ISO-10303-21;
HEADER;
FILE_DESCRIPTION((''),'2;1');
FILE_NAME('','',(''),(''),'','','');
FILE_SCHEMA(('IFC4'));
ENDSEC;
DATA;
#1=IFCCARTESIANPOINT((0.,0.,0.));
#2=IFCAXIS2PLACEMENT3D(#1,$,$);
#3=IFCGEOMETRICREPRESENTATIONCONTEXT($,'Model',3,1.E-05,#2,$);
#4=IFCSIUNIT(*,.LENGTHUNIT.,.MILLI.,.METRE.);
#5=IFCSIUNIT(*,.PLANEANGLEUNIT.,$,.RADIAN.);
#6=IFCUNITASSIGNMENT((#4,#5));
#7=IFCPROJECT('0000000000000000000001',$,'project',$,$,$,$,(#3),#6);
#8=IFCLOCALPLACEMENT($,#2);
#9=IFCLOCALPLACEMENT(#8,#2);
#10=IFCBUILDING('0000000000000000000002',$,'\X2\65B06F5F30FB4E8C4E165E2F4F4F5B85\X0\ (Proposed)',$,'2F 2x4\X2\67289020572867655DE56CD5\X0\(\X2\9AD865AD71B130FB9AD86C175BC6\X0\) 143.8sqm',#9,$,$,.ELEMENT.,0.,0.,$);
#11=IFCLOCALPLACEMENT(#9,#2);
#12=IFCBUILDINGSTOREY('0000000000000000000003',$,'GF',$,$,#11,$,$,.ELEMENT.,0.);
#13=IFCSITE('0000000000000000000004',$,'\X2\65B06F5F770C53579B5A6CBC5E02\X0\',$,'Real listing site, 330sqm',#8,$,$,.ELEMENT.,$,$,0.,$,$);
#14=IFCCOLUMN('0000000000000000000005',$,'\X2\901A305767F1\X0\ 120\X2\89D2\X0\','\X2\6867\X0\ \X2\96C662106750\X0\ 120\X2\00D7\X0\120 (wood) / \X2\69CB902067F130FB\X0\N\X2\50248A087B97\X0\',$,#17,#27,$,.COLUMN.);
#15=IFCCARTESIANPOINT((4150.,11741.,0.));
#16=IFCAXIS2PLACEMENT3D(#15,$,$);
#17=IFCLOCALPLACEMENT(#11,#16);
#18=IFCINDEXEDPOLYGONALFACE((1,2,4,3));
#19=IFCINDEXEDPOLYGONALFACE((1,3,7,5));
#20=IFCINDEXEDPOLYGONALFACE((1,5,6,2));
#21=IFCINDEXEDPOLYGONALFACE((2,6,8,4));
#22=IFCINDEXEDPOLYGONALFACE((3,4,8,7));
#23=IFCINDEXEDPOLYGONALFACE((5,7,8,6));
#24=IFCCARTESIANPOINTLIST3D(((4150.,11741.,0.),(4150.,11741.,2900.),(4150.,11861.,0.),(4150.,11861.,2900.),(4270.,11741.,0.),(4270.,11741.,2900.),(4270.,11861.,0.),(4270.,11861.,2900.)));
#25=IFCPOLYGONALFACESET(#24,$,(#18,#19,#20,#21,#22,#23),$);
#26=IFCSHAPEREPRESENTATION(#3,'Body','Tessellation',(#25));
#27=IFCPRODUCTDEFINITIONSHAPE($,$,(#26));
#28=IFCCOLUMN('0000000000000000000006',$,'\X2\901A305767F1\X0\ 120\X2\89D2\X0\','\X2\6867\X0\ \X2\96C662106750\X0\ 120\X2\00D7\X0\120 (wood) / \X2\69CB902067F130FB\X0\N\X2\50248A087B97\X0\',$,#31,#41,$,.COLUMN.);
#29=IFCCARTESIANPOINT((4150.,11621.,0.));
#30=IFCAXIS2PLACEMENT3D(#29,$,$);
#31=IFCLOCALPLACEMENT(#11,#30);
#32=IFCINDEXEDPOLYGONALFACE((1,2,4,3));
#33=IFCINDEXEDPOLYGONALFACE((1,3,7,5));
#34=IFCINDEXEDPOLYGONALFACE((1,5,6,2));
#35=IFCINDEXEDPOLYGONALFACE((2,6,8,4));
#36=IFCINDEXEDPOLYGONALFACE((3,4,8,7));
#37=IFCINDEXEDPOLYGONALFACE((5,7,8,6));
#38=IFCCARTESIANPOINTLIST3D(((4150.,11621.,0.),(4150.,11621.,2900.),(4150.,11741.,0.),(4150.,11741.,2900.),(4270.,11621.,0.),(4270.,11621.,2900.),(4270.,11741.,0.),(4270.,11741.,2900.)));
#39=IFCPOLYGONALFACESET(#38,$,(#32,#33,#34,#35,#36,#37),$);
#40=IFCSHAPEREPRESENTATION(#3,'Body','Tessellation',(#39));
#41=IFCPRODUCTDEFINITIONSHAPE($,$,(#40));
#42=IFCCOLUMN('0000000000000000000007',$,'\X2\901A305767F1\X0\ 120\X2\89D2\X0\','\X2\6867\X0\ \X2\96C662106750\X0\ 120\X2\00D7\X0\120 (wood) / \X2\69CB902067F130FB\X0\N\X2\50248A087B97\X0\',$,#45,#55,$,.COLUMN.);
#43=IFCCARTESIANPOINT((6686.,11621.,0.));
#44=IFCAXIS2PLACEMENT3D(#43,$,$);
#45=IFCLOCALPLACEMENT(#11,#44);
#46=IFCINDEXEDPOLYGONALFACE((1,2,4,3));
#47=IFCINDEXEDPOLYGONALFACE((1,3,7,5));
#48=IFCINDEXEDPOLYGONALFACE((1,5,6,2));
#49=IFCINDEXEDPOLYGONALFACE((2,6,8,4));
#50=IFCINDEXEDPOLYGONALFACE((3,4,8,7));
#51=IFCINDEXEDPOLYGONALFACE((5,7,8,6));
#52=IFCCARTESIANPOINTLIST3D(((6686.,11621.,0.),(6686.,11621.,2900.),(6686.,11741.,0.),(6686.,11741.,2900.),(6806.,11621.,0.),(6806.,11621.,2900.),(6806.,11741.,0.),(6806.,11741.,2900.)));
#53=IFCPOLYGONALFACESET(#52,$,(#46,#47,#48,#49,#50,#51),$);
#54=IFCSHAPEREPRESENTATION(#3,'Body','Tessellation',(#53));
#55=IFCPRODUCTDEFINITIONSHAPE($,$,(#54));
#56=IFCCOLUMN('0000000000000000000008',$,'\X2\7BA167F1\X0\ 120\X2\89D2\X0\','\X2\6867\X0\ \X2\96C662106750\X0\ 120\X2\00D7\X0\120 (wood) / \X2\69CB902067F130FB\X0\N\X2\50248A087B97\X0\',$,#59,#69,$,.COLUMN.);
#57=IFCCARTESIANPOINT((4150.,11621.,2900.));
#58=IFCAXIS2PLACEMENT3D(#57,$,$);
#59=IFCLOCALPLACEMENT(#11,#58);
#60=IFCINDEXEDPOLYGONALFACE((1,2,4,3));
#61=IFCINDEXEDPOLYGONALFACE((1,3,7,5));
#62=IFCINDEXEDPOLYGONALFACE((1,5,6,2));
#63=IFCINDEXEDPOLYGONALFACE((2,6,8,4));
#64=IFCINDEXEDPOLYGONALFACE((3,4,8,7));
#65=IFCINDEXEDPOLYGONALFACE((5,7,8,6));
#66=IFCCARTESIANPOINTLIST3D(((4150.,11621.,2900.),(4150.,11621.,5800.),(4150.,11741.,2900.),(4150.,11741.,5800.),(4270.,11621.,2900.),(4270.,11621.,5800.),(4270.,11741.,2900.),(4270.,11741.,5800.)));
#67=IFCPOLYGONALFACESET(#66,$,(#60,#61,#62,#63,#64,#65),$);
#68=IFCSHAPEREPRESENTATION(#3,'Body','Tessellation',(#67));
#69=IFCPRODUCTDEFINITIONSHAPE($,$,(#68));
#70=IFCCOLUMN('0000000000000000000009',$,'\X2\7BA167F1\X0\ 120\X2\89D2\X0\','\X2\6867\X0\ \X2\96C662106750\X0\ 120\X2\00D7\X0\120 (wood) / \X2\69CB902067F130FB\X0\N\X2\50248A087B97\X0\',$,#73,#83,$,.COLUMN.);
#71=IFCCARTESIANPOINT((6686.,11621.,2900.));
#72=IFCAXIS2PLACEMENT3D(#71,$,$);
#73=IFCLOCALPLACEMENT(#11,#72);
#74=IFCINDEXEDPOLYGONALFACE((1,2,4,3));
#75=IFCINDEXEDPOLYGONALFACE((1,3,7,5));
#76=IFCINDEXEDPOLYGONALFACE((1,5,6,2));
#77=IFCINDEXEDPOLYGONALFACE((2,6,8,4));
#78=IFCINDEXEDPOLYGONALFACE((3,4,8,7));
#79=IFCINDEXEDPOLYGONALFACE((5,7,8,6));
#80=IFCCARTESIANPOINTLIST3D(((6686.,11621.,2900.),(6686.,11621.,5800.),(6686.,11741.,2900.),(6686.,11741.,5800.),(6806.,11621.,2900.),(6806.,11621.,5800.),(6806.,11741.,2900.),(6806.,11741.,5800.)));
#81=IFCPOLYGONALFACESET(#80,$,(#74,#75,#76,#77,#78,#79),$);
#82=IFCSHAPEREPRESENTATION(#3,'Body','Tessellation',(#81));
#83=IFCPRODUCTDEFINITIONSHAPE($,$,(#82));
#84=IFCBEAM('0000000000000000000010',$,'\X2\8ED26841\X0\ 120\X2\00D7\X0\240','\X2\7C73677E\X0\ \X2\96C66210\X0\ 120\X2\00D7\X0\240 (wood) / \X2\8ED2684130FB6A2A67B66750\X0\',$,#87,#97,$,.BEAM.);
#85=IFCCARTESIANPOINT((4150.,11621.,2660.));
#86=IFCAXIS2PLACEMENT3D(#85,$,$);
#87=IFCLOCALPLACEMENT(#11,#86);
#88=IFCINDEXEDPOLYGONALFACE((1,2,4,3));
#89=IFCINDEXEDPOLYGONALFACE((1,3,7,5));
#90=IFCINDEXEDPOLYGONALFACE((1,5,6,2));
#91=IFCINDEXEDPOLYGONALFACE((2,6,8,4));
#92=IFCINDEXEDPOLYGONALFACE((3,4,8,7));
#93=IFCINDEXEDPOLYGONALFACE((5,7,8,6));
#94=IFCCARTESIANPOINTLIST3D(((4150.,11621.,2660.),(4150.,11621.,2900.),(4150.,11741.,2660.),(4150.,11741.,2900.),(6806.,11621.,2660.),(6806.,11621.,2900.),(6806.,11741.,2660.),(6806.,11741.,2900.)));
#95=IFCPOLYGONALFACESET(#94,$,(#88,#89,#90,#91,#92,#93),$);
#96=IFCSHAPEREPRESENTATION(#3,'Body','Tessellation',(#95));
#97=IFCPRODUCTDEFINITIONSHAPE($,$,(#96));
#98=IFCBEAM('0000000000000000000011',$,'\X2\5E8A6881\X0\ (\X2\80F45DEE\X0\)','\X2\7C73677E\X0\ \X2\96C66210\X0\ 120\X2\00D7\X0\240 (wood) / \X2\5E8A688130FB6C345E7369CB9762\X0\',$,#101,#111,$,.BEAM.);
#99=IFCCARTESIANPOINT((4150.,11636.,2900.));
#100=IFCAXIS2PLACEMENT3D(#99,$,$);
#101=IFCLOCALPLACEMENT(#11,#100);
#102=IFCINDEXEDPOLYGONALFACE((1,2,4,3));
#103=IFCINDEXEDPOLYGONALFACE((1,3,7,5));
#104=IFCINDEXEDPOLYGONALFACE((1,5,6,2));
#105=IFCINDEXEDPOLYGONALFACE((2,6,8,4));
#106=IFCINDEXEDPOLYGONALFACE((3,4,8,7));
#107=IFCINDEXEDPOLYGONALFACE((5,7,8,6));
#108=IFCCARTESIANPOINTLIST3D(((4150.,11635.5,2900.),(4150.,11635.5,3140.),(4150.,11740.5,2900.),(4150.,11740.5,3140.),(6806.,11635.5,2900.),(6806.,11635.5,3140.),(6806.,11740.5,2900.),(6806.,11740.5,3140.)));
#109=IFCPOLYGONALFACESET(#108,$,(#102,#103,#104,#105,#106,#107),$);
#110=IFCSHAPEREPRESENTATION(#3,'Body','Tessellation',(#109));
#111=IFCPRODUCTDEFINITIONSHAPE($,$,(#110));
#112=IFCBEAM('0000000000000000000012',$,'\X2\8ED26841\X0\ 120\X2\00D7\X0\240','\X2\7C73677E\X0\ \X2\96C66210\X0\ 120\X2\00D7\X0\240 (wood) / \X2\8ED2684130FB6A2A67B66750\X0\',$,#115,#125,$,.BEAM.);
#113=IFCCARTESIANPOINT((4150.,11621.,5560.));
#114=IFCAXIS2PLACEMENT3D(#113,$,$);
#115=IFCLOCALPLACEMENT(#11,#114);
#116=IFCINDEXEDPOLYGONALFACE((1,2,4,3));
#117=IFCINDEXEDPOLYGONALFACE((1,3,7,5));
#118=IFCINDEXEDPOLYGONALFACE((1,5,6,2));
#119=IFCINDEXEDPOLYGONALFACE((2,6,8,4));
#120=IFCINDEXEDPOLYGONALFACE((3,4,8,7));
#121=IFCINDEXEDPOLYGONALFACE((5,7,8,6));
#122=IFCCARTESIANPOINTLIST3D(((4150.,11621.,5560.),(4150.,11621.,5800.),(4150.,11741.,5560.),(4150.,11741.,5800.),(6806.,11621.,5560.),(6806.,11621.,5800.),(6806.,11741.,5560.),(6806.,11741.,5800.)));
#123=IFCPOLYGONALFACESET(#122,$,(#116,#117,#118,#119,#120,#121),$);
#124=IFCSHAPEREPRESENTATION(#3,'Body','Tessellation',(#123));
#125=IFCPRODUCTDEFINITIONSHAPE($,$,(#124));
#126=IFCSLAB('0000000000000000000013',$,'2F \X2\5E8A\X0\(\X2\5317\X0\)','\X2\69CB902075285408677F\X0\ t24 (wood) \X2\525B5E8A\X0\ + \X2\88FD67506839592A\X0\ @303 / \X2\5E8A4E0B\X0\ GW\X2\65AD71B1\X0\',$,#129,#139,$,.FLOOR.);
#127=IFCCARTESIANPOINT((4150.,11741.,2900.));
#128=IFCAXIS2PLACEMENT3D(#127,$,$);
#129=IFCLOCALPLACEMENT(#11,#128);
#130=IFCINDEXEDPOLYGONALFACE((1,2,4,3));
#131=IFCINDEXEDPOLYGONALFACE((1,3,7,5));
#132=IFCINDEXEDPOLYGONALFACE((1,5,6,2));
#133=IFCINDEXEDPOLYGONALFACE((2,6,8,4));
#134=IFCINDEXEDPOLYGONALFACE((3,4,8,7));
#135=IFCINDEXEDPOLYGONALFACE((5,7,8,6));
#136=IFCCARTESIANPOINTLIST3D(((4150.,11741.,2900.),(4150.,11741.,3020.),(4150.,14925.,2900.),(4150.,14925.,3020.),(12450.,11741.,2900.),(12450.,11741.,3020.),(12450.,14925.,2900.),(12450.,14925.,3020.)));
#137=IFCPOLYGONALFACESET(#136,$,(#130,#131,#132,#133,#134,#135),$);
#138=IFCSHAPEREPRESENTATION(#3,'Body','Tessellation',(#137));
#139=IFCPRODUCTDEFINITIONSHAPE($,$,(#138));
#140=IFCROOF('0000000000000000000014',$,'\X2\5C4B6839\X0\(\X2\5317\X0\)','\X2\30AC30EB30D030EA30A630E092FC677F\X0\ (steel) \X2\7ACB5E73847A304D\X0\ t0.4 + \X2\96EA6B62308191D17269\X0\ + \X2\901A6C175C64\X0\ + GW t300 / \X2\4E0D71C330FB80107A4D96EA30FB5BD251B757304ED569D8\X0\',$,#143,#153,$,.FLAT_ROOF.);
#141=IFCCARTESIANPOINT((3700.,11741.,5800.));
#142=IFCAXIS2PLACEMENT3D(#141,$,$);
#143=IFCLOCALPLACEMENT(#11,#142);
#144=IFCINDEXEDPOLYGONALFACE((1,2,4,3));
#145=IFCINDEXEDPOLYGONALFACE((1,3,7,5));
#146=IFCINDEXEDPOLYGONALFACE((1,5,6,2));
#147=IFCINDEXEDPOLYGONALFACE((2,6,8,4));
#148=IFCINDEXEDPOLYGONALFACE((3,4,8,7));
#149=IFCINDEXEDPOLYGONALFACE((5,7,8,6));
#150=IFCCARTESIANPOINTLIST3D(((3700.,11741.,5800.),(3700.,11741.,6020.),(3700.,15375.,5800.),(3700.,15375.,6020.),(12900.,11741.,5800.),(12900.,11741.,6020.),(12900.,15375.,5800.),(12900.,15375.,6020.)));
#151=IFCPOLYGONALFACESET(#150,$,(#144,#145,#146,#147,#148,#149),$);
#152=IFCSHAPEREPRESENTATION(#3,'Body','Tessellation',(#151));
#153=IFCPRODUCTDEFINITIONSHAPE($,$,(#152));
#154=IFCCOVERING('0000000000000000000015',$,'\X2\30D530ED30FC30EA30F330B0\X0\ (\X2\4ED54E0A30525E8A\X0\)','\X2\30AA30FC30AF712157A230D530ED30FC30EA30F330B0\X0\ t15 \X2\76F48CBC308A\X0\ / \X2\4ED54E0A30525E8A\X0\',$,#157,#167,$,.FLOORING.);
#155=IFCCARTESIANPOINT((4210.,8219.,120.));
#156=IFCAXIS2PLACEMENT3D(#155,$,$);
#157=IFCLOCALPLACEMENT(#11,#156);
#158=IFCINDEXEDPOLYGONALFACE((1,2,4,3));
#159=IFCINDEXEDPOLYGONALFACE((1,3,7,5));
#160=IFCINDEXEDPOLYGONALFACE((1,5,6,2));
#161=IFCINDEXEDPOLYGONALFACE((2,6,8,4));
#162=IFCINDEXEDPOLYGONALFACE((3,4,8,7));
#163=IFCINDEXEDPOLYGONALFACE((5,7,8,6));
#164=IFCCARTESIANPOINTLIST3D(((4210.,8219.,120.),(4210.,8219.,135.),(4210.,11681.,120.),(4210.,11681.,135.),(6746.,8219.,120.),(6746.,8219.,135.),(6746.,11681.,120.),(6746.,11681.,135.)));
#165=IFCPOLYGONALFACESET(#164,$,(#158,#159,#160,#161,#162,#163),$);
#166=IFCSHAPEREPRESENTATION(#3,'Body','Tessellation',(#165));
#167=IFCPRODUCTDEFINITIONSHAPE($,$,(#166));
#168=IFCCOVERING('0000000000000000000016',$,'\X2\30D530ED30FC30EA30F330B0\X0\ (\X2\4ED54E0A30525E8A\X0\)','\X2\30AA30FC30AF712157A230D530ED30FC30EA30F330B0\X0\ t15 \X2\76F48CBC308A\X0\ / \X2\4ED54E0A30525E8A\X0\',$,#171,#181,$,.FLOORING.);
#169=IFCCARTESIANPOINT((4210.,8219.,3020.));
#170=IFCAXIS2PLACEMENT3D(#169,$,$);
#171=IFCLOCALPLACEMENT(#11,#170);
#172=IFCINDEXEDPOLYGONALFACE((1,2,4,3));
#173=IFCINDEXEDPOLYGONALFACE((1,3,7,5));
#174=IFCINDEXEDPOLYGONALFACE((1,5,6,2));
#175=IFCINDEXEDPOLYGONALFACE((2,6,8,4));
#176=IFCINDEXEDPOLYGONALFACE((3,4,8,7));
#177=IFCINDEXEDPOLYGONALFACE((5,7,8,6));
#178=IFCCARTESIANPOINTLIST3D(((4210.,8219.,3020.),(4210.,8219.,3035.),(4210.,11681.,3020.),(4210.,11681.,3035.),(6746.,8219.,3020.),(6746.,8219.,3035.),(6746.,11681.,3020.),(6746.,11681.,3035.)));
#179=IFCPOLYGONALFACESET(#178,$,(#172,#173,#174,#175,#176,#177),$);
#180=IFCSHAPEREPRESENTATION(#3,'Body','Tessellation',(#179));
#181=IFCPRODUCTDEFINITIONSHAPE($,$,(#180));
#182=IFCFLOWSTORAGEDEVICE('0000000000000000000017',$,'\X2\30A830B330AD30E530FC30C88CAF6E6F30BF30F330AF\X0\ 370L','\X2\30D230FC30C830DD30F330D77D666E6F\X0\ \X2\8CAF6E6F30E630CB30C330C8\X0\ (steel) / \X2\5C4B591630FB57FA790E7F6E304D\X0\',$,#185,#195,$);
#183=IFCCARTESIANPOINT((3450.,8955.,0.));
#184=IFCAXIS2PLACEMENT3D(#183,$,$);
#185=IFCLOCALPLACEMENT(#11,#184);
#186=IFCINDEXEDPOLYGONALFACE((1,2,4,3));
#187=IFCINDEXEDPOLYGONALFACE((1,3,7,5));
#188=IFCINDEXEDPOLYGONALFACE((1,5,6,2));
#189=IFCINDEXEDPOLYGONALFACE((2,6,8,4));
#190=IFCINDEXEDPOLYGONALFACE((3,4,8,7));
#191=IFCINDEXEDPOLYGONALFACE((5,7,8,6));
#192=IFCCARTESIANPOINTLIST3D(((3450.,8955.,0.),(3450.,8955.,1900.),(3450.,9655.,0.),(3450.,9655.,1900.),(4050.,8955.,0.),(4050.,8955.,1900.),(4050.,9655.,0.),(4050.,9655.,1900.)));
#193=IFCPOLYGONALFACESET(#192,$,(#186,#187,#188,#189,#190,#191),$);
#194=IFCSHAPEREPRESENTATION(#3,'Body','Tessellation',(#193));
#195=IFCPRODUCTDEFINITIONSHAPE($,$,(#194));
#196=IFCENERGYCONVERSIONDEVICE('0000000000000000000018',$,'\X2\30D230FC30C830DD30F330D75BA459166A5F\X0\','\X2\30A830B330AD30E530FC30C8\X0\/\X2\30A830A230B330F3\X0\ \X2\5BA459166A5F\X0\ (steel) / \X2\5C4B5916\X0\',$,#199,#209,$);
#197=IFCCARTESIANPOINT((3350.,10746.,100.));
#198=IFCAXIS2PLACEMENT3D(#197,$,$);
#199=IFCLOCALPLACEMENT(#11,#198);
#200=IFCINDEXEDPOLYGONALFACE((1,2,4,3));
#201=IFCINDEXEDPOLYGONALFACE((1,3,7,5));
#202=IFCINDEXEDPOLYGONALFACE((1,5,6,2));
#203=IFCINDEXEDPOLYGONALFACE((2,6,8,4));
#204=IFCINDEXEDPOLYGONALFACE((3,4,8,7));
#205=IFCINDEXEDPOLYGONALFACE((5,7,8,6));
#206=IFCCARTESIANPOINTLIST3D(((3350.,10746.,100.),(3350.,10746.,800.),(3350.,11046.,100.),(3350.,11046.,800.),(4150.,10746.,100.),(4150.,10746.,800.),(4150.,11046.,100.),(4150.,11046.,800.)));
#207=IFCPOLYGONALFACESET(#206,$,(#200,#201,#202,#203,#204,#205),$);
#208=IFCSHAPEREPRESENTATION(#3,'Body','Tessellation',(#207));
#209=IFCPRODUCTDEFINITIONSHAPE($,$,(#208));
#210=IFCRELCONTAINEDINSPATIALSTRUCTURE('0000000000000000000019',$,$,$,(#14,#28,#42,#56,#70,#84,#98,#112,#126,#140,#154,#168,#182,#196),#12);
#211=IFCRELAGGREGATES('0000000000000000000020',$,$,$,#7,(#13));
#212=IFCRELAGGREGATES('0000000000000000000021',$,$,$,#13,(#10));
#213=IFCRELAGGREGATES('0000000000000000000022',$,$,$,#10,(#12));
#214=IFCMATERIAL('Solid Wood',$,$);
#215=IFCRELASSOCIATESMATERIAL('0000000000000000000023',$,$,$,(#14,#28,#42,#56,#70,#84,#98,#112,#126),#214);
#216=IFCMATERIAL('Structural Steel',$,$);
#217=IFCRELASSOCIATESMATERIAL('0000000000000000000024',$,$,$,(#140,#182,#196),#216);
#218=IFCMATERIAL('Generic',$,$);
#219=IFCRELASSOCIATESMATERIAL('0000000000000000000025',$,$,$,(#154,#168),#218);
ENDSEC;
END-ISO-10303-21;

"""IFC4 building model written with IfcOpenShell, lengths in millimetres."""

from ifc_helpers import new_model, si_unit, frame, frame_2d, origin, place, context, project, spatial, rectangle, extrude, material, element, save


model = new_model("IFC4")

# Units and contexts
model_context = context("Model", 3, precision=1e-05, world=origin())
ifc_project = project(units=[si_unit("LENGTHUNIT", "METRE", prefix="MILLI"), si_unit("PLANEANGLEUNIT", "RADIAN")], contexts=[model_context])

# Site, building, storey
site_placement = place(None, origin())
site = spatial("IfcSite", under=ifc_project, at=site_placement, Name="新潟県南魚沼市", ObjectType="Real listing site, 330sqm", CompositionType="ELEMENT", RefElevation=0.0)
building_placement = place(site_placement, origin())
building = spatial("IfcBuilding", under=site, at=building_placement, Name="新潟・二世帯住宅 (Proposed)", ObjectType="2F 2x4木造在来工法(高断熱・高気密) 143.8sqm", CompositionType="ELEMENT", ElevationOfRefHeight=0.0, ElevationOfTerrain=0.0)
storey_placement = place(building_placement, origin())
storey = spatial("IfcBuildingStorey", under=building, at=storey_placement, Name="GF", CompositionType="ELEMENT", Elevation=0.0)

# Columns
ifc_material_1 = material(Name="Solid Wood")
column_1_placement = place(storey_placement, frame((4150.0, 11741.0, 0.0)))
element("IfcColumn", 1, at=column_1_placement, inside=storey, material=ifc_material_1, Name="通し柱 120角", Description="桧 集成材 120×120 (wood) / 構造柱・N値計算", PredefinedType="COLUMN", context=model_context, shape_type="SweptSolid", body=[
    extrude(rectangle(XDim=120.0, YDim=120.0, at=frame_2d((60.0, 60.0))), frame((4150.0, 11741.0, 0.0)), (0.0, 0.0, 1.0), 2900.0),
])
column_2_placement = place(storey_placement, frame((4150.0, 11621.0, 0.0)))
element("IfcColumn", 2, at=column_2_placement, inside=storey, material=ifc_material_1, Name="通し柱 120角", Description="桧 集成材 120×120 (wood) / 構造柱・N値計算", PredefinedType="COLUMN", context=model_context, shape_type="SweptSolid", body=[
    extrude(rectangle(XDim=120.0, YDim=120.0, at=frame_2d((60.0, 60.0))), frame((4150.0, 11621.0, 0.0)), (0.0, 0.0, 1.0), 2900.0),
])
column_3_placement = place(storey_placement, frame((6686.0, 11621.0, 0.0)))
element("IfcColumn", 3, at=column_3_placement, inside=storey, material=ifc_material_1, Name="通し柱 120角", Description="桧 集成材 120×120 (wood) / 構造柱・N値計算", PredefinedType="COLUMN", context=model_context, shape_type="SweptSolid", body=[
    extrude(rectangle(XDim=120.0, YDim=120.0, at=frame_2d((60.0, 60.0))), frame((6686.0, 11621.0, 0.0)), (0.0, 0.0, 1.0), 2900.0),
])
column_4_placement = place(storey_placement, frame((4150.0, 11621.0, 2900.0)))
element("IfcColumn", 4, at=column_4_placement, inside=storey, material=ifc_material_1, Name="管柱 120角", Description="桧 集成材 120×120 (wood) / 構造柱・N値計算", PredefinedType="COLUMN", context=model_context, shape_type="SweptSolid", body=[
    extrude(rectangle(XDim=120.0, YDim=120.0, at=frame_2d((60.0, 60.0))), frame((4150.0, 11621.0, 2900.0)), (0.0, 0.0, 1.0), 2900.0),
])
column_5_placement = place(storey_placement, frame((6686.0, 11621.0, 2900.0)))
element("IfcColumn", 5, at=column_5_placement, inside=storey, material=ifc_material_1, Name="管柱 120角", Description="桧 集成材 120×120 (wood) / 構造柱・N値計算", PredefinedType="COLUMN", context=model_context, shape_type="SweptSolid", body=[
    extrude(rectangle(XDim=120.0, YDim=120.0, at=frame_2d((60.0, 60.0))), frame((6686.0, 11621.0, 2900.0)), (0.0, 0.0, 1.0), 2900.0),
])

# Beams
beam_1_placement = place(storey_placement, frame((4150.0, 11621.0, 2660.0)))
element("IfcBeam", 6, at=beam_1_placement, inside=storey, material=ifc_material_1, Name="軒桁 120×240", Description="米松 集成 120×240 (wood) / 軒桁・横架材", PredefinedType="BEAM", context=model_context, shape_type="SweptSolid", body=[
    extrude(rectangle(XDim=2656.0, YDim=120.0, at=frame_2d((1328.0, 60.0))), frame((4150.0, 11621.0, 2660.0)), (0.0, 0.0, 1.0), 240.0),
])
beam_2_placement = place(storey_placement, frame((4150.0, 11636.0, 2900.0)))
element("IfcBeam", 7, at=beam_2_placement, inside=storey, material=ifc_material_1, Name="床梁 (胴差)", Description="米松 集成 120×240 (wood) / 床梁・水平構面", PredefinedType="BEAM", context=model_context, shape_type="SweptSolid", body=[
    extrude(rectangle(XDim=2656.0, YDim=105.0, at=frame_2d((1328.0, 52.0))), frame((4150.0, 11636.0, 2900.0)), (0.0, 0.0, 1.0), 240.0),
])
beam_3_placement = place(storey_placement, frame((4150.0, 11621.0, 5560.0)))
element("IfcBeam", 8, at=beam_3_placement, inside=storey, material=ifc_material_1, Name="軒桁 120×240", Description="米松 集成 120×240 (wood) / 軒桁・横架材", PredefinedType="BEAM", context=model_context, shape_type="SweptSolid", body=[
    extrude(rectangle(XDim=2656.0, YDim=120.0, at=frame_2d((1328.0, 60.0))), frame((4150.0, 11621.0, 5560.0)), (0.0, 0.0, 1.0), 240.0),
])

# Slab
slab_1_placement = place(storey_placement, frame((4150.0, 11741.0, 2900.0)))
element("IfcSlab", 9, at=slab_1_placement, inside=storey, material=ifc_material_1, Name="2F 床(北)", Description="構造用合板 t24 (wood) 剛床 + 製材根太 @303 / 床下 GW断熱", PredefinedType="FLOOR", context=model_context, shape_type="SweptSolid", body=[
    extrude(rectangle(XDim=8300.0, YDim=3184.0, at=frame_2d((4150.0, 1592.0))), frame((4150.0, 11741.0, 2900.0)), (0.0, 0.0, 1.0), 120.0),
])

# Roof
ifc_material_2 = material(Name="Structural Steel")
for number, where, name in (
    (10, (3700.0, 11741.0, 5800.0), "屋根(北)"),
):
    element("IfcRoof", number, at=place(storey_placement, frame(where)), inside=storey, material=ifc_material_2, Name=name, Description="ガルバリウム鋼板 (steel) 立平葺き t0.4 + 雪止め金物 + 通気層 + GW t300 / 不燃・耐積雪・寒冷地仕様", PredefinedType="FLAT_ROOF", context=model_context, shape_type="SweptSolid", body=[
        extrude(rectangle(XDim=9200.0, YDim=3634.0, at=frame_2d((4600.0, 1817.0))), frame((3700.0, 11741.0, 5800.0)), (0.0, 0.0, 1.0), 220.0),
    ])

# Coverings
ifc_material_3 = material(Name="Generic")
covering_1_placement = place(storey_placement, frame((4210.0, 8219.0, 120.0)))
element("IfcCovering", 11, at=covering_1_placement, inside=storey, material=ifc_material_3, Name="フローリング (仕上げ床)", Description="オーク無垢フローリング t15 直貼り / 仕上げ床", PredefinedType="FLOORING", context=model_context, shape_type="SweptSolid", body=[
    extrude(rectangle(XDim=2536.0, YDim=3462.0, at=frame_2d((1268.0, 1731.0))), frame((4210.0, 8219.0, 120.0)), (0.0, 0.0, 1.0), 15.0),
])
covering_2_placement = place(storey_placement, frame((4210.0, 8219.0, 3020.0)))
element("IfcCovering", 12, at=covering_2_placement, inside=storey, material=ifc_material_3, Name="フローリング (仕上げ床)", Description="オーク無垢フローリング t15 直貼り / 仕上げ床", PredefinedType="FLOORING", context=model_context, shape_type="SweptSolid", body=[
    extrude(rectangle(XDim=2536.0, YDim=3462.0, at=frame_2d((1268.0, 1731.0))), frame((4210.0, 8219.0, 3020.0)), (0.0, 0.0, 1.0), 15.0),
])

# Flow storage device
flow_storage_device_placement = place(storey_placement, frame((3450.0, 8955.0, 0.0)))
element("IfcFlowStorageDevice", 13, at=flow_storage_device_placement, inside=storey, material=ifc_material_2, Name="エコキュート貯湯タンク 370L", Description="ヒートポンプ給湯 貯湯ユニット (steel) / 屋外・基礎置き", context=model_context, shape_type="SweptSolid", body=[
    extrude(rectangle(XDim=600.0, YDim=700.0, at=frame_2d((300.0, 350.0))), frame((3450.0, 8955.0, 0.0)), (0.0, 0.0, 1.0), 1900.0),
])

# Energy conversion device
energy_conversion_device_placement = place(storey_placement, frame((3350.0, 10746.0, 100.0)))
element("IfcEnergyConversionDevice", 14, at=energy_conversion_device_placement, inside=storey, material=ifc_material_2, Name="ヒートポンプ室外機", Description="エコキュート/エアコン 室外機 (steel) / 屋外", context=model_context, shape_type="SweptSolid", body=[
    extrude(rectangle(XDim=800.0, YDim=300.0, at=frame_2d((400.0, 150.0))), frame((3350.0, 10746.0, 100.0)), (0.0, 0.0, 1.0), 700.0),
])

save(model, "model.ifc")
